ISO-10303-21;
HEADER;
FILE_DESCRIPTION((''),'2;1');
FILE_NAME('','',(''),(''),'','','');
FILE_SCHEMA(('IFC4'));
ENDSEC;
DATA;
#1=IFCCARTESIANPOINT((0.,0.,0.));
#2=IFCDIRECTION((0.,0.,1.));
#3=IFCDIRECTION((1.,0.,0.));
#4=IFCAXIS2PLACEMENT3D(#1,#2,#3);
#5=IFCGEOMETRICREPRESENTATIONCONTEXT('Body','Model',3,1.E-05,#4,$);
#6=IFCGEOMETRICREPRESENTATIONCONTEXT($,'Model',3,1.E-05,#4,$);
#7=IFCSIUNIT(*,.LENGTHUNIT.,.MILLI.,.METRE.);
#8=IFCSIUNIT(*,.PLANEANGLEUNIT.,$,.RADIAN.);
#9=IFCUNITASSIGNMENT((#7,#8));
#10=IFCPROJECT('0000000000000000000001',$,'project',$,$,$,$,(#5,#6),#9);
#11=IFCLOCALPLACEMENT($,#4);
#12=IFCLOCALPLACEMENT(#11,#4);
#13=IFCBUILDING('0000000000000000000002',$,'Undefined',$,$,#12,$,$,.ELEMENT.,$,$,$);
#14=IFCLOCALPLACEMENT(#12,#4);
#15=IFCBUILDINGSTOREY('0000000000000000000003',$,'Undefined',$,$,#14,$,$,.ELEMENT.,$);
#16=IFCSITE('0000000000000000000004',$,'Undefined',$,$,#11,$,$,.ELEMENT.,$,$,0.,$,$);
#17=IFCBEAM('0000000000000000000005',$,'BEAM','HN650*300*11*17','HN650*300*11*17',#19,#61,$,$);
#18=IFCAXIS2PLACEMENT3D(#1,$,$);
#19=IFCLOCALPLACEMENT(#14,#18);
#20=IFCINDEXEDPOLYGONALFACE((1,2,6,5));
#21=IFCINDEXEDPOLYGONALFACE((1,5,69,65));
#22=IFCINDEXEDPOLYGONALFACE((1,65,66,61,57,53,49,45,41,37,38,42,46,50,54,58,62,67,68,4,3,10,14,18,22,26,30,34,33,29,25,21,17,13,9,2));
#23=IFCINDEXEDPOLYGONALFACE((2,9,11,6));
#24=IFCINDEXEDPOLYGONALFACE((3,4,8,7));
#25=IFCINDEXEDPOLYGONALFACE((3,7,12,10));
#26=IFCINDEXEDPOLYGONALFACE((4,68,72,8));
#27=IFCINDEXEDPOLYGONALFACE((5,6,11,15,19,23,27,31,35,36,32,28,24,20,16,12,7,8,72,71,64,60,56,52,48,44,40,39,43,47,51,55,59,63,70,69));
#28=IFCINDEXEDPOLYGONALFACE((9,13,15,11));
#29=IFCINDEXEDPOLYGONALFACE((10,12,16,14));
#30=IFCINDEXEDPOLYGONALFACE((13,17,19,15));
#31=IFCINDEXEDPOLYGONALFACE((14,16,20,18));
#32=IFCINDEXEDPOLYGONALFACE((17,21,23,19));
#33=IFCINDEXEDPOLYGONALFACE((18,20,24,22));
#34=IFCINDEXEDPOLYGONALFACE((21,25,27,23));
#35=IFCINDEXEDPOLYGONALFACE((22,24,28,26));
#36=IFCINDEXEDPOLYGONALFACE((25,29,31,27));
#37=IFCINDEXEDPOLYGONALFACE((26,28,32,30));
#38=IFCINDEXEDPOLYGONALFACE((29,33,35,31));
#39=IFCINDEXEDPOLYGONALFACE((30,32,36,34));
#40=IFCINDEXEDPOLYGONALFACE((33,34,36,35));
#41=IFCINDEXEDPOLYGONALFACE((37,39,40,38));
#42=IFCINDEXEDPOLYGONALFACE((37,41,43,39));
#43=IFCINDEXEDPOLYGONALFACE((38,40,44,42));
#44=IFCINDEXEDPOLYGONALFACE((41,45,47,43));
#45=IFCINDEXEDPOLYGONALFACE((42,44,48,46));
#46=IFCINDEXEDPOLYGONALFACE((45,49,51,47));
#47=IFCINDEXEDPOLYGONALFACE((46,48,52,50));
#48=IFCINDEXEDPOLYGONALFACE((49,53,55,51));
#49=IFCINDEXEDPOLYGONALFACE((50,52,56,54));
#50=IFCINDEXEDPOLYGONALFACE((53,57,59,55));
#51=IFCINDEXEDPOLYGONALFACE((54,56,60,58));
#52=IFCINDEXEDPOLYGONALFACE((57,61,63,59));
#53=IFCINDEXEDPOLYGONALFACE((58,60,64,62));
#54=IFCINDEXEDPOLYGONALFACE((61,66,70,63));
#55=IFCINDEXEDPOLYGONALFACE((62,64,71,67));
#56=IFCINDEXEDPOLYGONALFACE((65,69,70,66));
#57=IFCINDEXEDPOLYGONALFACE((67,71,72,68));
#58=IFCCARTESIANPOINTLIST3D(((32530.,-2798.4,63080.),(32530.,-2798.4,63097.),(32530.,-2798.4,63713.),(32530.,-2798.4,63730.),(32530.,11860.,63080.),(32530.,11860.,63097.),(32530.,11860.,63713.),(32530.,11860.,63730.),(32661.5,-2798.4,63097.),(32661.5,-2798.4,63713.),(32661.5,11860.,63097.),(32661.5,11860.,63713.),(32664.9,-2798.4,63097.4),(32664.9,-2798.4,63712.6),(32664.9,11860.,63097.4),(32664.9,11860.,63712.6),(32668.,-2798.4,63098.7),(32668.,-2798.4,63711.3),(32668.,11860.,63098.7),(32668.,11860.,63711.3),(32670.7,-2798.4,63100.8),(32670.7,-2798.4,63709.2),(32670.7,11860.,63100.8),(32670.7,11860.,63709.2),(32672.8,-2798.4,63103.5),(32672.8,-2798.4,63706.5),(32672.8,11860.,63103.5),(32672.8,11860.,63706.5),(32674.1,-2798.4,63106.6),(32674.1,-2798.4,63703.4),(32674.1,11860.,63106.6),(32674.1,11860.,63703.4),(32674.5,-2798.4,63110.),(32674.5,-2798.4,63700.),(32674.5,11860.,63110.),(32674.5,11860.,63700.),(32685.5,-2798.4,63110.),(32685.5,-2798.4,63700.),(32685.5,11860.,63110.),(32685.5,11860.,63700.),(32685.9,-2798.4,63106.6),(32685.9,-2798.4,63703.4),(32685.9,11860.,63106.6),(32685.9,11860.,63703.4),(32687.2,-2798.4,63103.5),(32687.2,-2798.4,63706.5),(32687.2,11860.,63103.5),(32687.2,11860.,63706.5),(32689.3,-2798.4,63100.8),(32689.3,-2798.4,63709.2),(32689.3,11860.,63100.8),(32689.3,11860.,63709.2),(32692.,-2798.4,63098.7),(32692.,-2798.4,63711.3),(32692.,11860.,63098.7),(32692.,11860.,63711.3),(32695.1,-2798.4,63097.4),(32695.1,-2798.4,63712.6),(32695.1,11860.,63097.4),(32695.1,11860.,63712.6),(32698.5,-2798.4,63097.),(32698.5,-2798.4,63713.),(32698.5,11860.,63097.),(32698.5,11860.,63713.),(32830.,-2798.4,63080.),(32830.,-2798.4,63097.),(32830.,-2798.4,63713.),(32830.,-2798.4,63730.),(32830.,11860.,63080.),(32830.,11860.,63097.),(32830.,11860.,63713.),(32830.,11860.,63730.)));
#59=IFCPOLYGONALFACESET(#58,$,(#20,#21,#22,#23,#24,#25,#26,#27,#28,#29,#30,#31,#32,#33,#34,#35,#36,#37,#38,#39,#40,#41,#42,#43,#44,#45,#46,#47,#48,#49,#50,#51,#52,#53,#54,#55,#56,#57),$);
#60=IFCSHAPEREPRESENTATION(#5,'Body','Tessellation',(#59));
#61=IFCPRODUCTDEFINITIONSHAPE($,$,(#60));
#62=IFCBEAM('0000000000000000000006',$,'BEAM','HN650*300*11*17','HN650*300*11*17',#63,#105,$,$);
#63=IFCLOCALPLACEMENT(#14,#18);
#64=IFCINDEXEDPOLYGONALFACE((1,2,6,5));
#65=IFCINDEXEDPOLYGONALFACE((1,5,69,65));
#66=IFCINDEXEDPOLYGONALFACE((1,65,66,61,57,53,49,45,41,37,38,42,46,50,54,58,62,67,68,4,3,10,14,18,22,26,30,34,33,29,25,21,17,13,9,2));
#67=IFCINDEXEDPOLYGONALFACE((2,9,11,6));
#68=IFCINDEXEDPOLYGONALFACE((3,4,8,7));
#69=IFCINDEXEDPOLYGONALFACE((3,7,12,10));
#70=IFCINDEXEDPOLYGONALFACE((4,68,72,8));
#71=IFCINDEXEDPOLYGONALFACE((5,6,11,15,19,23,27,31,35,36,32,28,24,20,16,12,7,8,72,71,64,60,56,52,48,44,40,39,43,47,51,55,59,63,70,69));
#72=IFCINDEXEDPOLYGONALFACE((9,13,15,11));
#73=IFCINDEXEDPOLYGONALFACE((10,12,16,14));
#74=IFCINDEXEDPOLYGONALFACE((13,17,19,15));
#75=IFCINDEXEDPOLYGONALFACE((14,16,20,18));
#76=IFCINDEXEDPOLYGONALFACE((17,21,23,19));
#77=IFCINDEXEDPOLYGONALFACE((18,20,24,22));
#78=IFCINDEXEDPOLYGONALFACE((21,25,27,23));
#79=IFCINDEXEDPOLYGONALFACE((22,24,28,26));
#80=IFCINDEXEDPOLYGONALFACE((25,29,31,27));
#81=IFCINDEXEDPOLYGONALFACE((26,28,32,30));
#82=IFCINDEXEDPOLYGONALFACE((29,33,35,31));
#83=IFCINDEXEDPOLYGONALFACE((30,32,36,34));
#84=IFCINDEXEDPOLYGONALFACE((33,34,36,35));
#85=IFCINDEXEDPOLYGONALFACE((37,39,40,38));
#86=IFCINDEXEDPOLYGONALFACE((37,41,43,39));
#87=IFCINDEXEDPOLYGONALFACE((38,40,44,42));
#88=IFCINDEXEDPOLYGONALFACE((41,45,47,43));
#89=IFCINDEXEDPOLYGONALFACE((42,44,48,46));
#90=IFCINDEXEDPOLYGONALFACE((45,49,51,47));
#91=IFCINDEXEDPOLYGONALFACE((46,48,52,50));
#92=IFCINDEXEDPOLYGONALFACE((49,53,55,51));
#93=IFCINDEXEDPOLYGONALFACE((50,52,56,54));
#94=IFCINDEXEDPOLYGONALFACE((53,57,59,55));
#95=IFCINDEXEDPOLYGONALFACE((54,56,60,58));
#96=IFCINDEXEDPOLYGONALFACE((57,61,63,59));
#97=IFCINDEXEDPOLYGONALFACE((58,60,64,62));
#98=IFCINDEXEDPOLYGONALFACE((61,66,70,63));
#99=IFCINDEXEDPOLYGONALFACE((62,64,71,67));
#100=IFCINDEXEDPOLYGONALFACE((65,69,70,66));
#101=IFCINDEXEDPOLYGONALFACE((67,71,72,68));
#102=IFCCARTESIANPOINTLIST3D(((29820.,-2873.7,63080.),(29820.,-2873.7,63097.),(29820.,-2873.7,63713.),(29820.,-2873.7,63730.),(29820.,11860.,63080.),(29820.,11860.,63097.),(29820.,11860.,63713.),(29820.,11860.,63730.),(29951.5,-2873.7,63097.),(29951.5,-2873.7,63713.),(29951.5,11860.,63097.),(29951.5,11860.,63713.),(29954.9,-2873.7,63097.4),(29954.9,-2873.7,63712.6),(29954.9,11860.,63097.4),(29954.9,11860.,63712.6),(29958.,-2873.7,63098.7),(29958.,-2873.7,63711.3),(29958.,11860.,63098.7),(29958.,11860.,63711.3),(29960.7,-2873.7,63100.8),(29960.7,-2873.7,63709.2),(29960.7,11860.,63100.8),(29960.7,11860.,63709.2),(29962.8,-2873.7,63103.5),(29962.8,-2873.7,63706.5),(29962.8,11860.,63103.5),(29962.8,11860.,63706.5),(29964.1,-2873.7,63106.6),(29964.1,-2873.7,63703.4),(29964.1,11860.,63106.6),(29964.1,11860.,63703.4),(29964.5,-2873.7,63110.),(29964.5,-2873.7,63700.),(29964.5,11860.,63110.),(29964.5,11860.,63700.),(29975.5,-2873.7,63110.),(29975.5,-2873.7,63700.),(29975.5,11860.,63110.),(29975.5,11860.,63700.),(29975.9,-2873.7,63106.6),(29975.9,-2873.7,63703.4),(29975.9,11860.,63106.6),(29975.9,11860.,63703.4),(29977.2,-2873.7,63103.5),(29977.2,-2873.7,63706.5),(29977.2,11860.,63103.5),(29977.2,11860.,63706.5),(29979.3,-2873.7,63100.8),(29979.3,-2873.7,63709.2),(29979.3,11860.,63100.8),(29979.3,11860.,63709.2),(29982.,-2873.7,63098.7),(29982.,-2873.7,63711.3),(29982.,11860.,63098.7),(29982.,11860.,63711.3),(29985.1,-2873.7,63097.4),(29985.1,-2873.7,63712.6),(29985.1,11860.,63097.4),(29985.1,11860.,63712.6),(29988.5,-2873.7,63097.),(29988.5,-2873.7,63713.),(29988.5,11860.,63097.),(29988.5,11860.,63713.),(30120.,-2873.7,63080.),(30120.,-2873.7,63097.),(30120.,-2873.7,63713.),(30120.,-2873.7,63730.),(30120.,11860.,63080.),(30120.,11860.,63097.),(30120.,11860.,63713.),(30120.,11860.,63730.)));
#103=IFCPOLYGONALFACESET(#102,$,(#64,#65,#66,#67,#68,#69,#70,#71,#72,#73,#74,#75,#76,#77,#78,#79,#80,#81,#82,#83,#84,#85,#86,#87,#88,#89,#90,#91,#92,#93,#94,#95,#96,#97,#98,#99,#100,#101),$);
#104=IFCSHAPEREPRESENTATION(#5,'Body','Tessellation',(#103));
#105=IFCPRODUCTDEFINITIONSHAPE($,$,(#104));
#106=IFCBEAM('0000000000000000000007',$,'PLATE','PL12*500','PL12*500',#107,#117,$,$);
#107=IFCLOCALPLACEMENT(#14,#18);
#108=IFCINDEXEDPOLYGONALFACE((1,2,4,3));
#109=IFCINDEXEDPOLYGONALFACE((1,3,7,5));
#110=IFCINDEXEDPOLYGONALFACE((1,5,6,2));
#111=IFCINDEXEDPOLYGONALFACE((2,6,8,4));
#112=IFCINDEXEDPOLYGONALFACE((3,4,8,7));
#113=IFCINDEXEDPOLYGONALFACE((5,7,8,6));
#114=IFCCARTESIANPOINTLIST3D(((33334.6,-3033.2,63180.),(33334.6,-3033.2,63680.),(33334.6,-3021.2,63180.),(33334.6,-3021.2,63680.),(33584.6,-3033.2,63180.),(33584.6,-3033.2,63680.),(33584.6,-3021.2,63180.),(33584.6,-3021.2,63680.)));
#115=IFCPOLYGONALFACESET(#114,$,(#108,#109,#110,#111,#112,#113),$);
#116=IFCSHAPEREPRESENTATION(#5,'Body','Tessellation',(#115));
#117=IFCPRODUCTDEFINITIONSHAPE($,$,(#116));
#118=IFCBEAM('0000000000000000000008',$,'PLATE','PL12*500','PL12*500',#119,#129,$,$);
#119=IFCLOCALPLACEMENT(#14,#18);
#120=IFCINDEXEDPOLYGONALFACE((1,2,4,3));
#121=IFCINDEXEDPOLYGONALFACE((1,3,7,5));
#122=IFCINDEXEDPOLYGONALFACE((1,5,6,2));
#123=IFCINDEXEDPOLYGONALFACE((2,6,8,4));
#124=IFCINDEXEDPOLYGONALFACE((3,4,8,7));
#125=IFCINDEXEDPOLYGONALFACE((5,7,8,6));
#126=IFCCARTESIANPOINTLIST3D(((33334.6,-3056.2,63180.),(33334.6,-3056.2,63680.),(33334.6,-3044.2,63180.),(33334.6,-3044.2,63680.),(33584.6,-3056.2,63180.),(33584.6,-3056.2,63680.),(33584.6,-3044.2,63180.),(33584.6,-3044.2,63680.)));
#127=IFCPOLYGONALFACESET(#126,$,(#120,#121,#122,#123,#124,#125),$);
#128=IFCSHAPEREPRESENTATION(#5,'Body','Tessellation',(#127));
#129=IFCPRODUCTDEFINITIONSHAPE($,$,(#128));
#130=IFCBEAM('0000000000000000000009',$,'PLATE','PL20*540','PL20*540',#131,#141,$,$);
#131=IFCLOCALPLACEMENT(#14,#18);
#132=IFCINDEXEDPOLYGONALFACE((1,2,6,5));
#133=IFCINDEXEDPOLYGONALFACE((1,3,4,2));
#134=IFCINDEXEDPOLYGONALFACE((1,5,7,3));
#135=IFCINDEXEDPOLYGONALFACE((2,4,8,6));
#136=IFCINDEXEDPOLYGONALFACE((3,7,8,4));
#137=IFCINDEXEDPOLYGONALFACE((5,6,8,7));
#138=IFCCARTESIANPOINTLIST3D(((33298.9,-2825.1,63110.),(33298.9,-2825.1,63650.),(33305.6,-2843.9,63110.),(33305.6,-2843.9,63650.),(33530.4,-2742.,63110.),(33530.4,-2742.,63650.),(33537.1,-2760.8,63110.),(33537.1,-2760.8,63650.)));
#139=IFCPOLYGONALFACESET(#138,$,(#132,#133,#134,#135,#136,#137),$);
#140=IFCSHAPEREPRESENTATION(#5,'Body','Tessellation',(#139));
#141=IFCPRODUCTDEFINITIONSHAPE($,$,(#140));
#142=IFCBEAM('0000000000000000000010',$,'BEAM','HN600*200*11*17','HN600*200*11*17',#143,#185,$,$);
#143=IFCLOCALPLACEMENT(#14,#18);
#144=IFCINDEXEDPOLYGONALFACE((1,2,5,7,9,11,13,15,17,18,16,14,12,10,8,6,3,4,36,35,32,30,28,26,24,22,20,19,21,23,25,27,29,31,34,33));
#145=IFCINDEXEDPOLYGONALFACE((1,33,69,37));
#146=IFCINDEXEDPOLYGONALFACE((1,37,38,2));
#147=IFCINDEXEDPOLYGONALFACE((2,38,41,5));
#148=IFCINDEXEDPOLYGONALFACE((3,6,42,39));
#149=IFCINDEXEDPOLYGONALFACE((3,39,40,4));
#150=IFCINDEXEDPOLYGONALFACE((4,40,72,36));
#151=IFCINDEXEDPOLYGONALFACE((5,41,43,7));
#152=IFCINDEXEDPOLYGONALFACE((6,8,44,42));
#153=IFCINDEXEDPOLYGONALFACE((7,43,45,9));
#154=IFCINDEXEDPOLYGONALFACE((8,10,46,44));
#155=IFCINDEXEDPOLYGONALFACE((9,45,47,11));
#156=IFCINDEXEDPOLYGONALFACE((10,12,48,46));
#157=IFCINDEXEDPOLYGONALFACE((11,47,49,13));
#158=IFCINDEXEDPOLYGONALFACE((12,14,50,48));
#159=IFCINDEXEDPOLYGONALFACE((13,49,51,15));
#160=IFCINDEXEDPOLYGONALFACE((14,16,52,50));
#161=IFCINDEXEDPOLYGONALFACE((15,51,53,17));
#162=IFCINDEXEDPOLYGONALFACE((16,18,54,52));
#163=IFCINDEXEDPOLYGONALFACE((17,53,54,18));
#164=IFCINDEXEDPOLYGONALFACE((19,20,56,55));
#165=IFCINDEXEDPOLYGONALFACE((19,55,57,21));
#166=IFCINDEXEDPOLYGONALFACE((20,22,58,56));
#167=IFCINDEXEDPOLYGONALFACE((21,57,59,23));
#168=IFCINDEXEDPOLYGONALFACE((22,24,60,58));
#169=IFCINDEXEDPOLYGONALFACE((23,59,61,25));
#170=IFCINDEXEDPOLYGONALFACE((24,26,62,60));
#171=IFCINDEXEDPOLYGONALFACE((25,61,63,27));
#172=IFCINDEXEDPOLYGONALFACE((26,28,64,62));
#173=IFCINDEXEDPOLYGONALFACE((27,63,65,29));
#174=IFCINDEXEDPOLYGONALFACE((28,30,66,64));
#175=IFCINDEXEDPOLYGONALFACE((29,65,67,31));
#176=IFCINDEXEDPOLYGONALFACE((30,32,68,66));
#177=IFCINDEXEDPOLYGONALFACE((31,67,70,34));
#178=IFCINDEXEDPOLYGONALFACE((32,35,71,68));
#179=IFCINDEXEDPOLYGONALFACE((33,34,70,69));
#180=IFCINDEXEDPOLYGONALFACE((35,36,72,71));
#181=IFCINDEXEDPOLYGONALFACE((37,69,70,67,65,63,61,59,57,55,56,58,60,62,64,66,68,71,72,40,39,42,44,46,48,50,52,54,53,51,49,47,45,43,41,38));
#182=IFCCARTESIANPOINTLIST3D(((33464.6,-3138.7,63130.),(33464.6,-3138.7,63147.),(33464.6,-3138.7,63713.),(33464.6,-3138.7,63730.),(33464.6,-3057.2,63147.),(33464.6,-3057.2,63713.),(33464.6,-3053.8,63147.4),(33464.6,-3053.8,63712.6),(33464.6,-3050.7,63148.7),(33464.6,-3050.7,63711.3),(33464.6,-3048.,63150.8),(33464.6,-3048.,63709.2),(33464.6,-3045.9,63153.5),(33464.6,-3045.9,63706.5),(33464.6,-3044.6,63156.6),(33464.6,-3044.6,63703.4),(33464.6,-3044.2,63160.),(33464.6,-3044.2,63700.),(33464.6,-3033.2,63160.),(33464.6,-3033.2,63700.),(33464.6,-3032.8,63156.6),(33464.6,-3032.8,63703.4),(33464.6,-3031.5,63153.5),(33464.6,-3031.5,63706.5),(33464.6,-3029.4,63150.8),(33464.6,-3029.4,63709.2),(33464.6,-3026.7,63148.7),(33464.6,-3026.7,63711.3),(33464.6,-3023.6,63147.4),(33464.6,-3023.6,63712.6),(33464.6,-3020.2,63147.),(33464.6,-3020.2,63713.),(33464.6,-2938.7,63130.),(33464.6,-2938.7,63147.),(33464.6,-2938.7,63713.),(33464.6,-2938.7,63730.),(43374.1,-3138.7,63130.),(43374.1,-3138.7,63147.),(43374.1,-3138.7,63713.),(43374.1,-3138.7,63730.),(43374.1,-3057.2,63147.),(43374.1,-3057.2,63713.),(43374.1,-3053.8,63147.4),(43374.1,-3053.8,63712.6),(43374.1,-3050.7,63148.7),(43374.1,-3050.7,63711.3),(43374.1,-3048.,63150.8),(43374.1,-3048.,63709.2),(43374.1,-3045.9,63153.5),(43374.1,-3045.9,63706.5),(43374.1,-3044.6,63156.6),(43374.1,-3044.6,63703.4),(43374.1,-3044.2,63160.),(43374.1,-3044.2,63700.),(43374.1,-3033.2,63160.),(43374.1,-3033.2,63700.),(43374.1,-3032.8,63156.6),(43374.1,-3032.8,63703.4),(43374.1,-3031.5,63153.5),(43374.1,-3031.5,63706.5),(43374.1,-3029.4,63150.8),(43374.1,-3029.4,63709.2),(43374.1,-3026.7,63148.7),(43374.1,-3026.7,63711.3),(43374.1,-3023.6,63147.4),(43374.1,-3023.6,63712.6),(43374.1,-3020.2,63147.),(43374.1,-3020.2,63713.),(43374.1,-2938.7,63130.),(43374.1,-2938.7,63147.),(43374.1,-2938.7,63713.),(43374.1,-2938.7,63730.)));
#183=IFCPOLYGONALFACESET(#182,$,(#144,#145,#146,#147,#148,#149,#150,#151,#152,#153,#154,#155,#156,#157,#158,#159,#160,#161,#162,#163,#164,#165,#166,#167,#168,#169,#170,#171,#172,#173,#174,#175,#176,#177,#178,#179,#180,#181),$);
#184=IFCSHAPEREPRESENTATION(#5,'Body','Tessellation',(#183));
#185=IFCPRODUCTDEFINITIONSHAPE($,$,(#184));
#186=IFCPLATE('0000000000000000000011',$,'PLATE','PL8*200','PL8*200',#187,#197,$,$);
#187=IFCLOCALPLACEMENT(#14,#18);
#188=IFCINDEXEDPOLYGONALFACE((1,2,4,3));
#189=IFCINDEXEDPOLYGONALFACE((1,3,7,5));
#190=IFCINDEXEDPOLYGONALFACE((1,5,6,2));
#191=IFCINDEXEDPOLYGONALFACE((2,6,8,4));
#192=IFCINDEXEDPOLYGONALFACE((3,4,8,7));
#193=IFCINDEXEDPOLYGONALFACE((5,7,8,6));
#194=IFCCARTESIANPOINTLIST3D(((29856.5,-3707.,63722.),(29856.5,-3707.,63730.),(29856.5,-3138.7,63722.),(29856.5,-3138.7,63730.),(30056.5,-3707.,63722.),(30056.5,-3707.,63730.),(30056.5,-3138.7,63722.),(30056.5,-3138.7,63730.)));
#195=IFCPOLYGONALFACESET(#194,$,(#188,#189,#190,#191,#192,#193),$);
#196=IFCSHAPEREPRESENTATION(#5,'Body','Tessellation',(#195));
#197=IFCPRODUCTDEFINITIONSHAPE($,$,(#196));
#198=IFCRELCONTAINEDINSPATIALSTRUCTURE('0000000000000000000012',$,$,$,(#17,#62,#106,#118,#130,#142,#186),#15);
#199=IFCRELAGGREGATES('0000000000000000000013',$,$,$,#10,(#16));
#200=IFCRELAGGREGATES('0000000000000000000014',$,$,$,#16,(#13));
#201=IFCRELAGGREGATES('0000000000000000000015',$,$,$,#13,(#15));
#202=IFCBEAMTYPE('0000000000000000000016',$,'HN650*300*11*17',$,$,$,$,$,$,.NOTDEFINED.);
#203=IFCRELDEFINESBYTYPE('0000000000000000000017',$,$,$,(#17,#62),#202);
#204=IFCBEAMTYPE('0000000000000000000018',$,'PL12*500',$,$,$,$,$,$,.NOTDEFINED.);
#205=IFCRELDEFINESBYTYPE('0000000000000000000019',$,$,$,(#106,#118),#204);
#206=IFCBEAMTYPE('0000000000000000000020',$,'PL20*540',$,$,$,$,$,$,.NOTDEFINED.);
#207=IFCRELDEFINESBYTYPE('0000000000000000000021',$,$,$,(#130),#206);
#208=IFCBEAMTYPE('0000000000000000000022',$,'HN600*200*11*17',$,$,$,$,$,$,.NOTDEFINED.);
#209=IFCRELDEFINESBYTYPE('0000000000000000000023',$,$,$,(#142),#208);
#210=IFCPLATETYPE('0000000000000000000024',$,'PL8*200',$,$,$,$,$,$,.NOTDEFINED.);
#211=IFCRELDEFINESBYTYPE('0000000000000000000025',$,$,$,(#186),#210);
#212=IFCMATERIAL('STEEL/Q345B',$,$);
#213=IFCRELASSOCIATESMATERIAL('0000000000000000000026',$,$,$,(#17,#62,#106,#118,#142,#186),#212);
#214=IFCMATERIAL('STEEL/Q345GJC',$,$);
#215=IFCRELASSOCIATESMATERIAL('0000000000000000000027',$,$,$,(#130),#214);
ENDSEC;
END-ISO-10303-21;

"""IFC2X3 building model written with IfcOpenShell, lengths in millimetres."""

from ifc_helpers import new_model, si_unit, frame, origin_with_axes, origin_2d_with_axis, place, context, project, spatial, polyline, rectangle, i_section, outline, extrude, material, type_object, element, save


model = new_model("IFC2X3")

# Units and contexts
model_context_1 = context("Model", 3, precision=1e-05, world=origin_with_axes(), identifier="Body")
model_context_2 = context("Model", 3, precision=1e-05, world=origin_with_axes())
ifc_project = project(units=[si_unit("LENGTHUNIT", "METRE", prefix="MILLI"), si_unit("PLANEANGLEUNIT", "RADIAN")], contexts=[model_context_1, model_context_2])

# Site, building, storey
site_placement = place(None, origin_with_axes())
site = spatial("IfcSite", under=ifc_project, at=site_placement, Name="Undefined", CompositionType="ELEMENT", RefElevation=0.0)
building_placement = place(site_placement, origin_with_axes())
building = spatial("IfcBuilding", under=site, at=building_placement, Name="Undefined", CompositionType="ELEMENT")
storey_placement = place(building_placement, origin_with_axes())
storey = spatial("IfcBuildingStorey", under=building, at=storey_placement, Name="Undefined", CompositionType="ELEMENT")

# Beams
ifc_material_1 = material(Name="STEEL/Q345B")
beam_type_1 = type_object("IfcBeamType", Name="HN650*300*11*17", PredefinedType="NOTDEFINED")
beam_1_placement = place(storey_placement, frame((32680.0, 11880.0, 63405.0), z_axis=(0.0, 0.0, 1.0), x_axis=(0.0, -1.0, 0.0)))
element("IfcBeam", 1, at=beam_1_placement, inside=storey, type_object=beam_type_1, material=ifc_material_1, Name="BEAM", Description="HN650*300*11*17", ObjectType="HN650*300*11*17", context=model_context_1, shape_type="SweptSolid", body=[
    extrude(i_section(OverallWidth=300.0, OverallDepth=650.0, WebThickness=11.0, FlangeThickness=17.0, FilletRadius=13.0, at=origin_2d_with_axis()), frame((14678.4, 0.0, 0.0), z_axis=(-1.0, 0.0, 0.0), x_axis=(0.0, -1.0, 0.0)), (0.0, 0.0, 1.0), 14658.4),
])
beam_2_placement = place(storey_placement, frame((29970.0, 11880.0, 63405.0), z_axis=(0.0, 0.0, 1.0), x_axis=(0.0, -1.0, 0.0)))
element("IfcBeam", 2, at=beam_2_placement, inside=storey, type_object=beam_type_1, material=ifc_material_1, Name="BEAM", Description="HN650*300*11*17", ObjectType="HN650*300*11*17", context=model_context_1, shape_type="SweptSolid", body=[
    extrude(i_section(OverallWidth=300.0, OverallDepth=650.0, WebThickness=11.0, FlangeThickness=17.0, FilletRadius=13.0, at=origin_2d_with_axis()), frame((14753.7, 0.0, 0.0), z_axis=(-1.0, 0.0, 0.0), x_axis=(0.0, -1.0, 0.0)), (0.0, 0.0, 1.0), 14733.7),
])
beam_type_2 = type_object("IfcBeamType", Name="PL12*500", PredefinedType="NOTDEFINED")
for number, where, z_axis, x_axis, name in (
    (3, (33334.6, -3027.2, 63430.0), (0.0, 0.0, 1.0), (1.0, 0.0, 0.0), "PLATE"),
    (4, (33334.6, -3050.2, 63430.0), (0.0, 0.0, 1.0), (1.0, 0.0, 0.0), "PLATE"),
):
    element("IfcBeam", number, at=place(storey_placement, frame(where, z_axis=z_axis, x_axis=x_axis)), inside=storey, type_object=beam_type_2, material=ifc_material_1, Name=name, Description="PL12*500", ObjectType="PL12*500", context=model_context_1, shape_type="SweptSolid", body=[
        extrude(rectangle(XDim=12.0, YDim=500.0, at=origin_2d_with_axis()), frame((250.0, 0.0, 0.0), z_axis=(-1.0, 0.0, 0.0), x_axis=(0.0, -1.0, 0.0)), (0.0, 0.0, 1.0), 250.0),
    ])
ifc_material_2 = material(Name="STEEL/Q345GJC")
beam_type_3 = type_object("IfcBeamType", Name="PL20*540", PredefinedType="NOTDEFINED")
beam_3_placement = place(storey_placement, frame((33302.2, -2834.5, 63380.0), z_axis=(0.0, 0.0, 1.0), x_axis=(0.941212, 0.337816, 0.0)))
element("IfcBeam", 5, at=beam_3_placement, inside=storey, type_object=beam_type_3, material=ifc_material_2, Name="PLATE", Description="PL20*540", ObjectType="PL20*540", context=model_context_1, shape_type="SweptSolid", body=[
    extrude(rectangle(XDim=20.0, YDim=540.0, at=origin_2d_with_axis()), frame((246.0, 0.0, 0.0), z_axis=(-1.0, 0.0, 0.0), x_axis=(0.0, -1.0, 0.0)), (0.0, 0.0, 1.0), 246.0),
])
beam_type_4 = type_object("IfcBeamType", Name="HN600*200*11*17", PredefinedType="NOTDEFINED")
beam_4_placement = place(storey_placement, frame((32680.0, -3038.7, 63430.0), z_axis=(0.0, 0.0, 1.0), x_axis=(1.0, 0.0, 0.0)))
element("IfcBeam", 6, at=beam_4_placement, inside=storey, type_object=beam_type_4, material=ifc_material_1, Name="BEAM", Description="HN600*200*11*17", ObjectType="HN600*200*11*17", context=model_context_1, shape_type="SweptSolid", body=[
    extrude(i_section(OverallWidth=200.0, OverallDepth=600.0, WebThickness=11.0, FlangeThickness=17.0, FilletRadius=13.0, at=origin_2d_with_axis()), frame((10694.1, 0.0, 0.0), z_axis=(-1.0, 0.0, 0.0), x_axis=(0.0, -1.0, 0.0)), (0.0, 0.0, 1.0), 9909.5),
])

# Plate
plate_type_1 = type_object("IfcPlateType", Name="PL8*200", PredefinedType="NOTDEFINED")
plate_1_placement = place(storey_placement, frame((30056.5, -3707.0, 63726.0), z_axis=(0.0, 0.0, 1.0), x_axis=(0.0, 1.0, 0.0)))
element("IfcPlate", 7, at=plate_1_placement, inside=storey, type_object=plate_type_1, material=ifc_material_1, Name="PLATE", Description="PL8*200", ObjectType="PL8*200", context=model_context_1, shape_type="SweptSolid", body=[
    extrude(outline(polyline([(0.0, 0.0), (568.3, 0.0), (568.3, 200.0), (0.0, 200.0), (0.0, 0.0)])), frame((0.0, 0.0, -4.0), z_axis=(0.0, 0.0, 1.0), x_axis=(1.0, 0.0, 0.0)), (0.0, 0.0, 1.0), 8.0),
])

save(model, "model.ifc")
